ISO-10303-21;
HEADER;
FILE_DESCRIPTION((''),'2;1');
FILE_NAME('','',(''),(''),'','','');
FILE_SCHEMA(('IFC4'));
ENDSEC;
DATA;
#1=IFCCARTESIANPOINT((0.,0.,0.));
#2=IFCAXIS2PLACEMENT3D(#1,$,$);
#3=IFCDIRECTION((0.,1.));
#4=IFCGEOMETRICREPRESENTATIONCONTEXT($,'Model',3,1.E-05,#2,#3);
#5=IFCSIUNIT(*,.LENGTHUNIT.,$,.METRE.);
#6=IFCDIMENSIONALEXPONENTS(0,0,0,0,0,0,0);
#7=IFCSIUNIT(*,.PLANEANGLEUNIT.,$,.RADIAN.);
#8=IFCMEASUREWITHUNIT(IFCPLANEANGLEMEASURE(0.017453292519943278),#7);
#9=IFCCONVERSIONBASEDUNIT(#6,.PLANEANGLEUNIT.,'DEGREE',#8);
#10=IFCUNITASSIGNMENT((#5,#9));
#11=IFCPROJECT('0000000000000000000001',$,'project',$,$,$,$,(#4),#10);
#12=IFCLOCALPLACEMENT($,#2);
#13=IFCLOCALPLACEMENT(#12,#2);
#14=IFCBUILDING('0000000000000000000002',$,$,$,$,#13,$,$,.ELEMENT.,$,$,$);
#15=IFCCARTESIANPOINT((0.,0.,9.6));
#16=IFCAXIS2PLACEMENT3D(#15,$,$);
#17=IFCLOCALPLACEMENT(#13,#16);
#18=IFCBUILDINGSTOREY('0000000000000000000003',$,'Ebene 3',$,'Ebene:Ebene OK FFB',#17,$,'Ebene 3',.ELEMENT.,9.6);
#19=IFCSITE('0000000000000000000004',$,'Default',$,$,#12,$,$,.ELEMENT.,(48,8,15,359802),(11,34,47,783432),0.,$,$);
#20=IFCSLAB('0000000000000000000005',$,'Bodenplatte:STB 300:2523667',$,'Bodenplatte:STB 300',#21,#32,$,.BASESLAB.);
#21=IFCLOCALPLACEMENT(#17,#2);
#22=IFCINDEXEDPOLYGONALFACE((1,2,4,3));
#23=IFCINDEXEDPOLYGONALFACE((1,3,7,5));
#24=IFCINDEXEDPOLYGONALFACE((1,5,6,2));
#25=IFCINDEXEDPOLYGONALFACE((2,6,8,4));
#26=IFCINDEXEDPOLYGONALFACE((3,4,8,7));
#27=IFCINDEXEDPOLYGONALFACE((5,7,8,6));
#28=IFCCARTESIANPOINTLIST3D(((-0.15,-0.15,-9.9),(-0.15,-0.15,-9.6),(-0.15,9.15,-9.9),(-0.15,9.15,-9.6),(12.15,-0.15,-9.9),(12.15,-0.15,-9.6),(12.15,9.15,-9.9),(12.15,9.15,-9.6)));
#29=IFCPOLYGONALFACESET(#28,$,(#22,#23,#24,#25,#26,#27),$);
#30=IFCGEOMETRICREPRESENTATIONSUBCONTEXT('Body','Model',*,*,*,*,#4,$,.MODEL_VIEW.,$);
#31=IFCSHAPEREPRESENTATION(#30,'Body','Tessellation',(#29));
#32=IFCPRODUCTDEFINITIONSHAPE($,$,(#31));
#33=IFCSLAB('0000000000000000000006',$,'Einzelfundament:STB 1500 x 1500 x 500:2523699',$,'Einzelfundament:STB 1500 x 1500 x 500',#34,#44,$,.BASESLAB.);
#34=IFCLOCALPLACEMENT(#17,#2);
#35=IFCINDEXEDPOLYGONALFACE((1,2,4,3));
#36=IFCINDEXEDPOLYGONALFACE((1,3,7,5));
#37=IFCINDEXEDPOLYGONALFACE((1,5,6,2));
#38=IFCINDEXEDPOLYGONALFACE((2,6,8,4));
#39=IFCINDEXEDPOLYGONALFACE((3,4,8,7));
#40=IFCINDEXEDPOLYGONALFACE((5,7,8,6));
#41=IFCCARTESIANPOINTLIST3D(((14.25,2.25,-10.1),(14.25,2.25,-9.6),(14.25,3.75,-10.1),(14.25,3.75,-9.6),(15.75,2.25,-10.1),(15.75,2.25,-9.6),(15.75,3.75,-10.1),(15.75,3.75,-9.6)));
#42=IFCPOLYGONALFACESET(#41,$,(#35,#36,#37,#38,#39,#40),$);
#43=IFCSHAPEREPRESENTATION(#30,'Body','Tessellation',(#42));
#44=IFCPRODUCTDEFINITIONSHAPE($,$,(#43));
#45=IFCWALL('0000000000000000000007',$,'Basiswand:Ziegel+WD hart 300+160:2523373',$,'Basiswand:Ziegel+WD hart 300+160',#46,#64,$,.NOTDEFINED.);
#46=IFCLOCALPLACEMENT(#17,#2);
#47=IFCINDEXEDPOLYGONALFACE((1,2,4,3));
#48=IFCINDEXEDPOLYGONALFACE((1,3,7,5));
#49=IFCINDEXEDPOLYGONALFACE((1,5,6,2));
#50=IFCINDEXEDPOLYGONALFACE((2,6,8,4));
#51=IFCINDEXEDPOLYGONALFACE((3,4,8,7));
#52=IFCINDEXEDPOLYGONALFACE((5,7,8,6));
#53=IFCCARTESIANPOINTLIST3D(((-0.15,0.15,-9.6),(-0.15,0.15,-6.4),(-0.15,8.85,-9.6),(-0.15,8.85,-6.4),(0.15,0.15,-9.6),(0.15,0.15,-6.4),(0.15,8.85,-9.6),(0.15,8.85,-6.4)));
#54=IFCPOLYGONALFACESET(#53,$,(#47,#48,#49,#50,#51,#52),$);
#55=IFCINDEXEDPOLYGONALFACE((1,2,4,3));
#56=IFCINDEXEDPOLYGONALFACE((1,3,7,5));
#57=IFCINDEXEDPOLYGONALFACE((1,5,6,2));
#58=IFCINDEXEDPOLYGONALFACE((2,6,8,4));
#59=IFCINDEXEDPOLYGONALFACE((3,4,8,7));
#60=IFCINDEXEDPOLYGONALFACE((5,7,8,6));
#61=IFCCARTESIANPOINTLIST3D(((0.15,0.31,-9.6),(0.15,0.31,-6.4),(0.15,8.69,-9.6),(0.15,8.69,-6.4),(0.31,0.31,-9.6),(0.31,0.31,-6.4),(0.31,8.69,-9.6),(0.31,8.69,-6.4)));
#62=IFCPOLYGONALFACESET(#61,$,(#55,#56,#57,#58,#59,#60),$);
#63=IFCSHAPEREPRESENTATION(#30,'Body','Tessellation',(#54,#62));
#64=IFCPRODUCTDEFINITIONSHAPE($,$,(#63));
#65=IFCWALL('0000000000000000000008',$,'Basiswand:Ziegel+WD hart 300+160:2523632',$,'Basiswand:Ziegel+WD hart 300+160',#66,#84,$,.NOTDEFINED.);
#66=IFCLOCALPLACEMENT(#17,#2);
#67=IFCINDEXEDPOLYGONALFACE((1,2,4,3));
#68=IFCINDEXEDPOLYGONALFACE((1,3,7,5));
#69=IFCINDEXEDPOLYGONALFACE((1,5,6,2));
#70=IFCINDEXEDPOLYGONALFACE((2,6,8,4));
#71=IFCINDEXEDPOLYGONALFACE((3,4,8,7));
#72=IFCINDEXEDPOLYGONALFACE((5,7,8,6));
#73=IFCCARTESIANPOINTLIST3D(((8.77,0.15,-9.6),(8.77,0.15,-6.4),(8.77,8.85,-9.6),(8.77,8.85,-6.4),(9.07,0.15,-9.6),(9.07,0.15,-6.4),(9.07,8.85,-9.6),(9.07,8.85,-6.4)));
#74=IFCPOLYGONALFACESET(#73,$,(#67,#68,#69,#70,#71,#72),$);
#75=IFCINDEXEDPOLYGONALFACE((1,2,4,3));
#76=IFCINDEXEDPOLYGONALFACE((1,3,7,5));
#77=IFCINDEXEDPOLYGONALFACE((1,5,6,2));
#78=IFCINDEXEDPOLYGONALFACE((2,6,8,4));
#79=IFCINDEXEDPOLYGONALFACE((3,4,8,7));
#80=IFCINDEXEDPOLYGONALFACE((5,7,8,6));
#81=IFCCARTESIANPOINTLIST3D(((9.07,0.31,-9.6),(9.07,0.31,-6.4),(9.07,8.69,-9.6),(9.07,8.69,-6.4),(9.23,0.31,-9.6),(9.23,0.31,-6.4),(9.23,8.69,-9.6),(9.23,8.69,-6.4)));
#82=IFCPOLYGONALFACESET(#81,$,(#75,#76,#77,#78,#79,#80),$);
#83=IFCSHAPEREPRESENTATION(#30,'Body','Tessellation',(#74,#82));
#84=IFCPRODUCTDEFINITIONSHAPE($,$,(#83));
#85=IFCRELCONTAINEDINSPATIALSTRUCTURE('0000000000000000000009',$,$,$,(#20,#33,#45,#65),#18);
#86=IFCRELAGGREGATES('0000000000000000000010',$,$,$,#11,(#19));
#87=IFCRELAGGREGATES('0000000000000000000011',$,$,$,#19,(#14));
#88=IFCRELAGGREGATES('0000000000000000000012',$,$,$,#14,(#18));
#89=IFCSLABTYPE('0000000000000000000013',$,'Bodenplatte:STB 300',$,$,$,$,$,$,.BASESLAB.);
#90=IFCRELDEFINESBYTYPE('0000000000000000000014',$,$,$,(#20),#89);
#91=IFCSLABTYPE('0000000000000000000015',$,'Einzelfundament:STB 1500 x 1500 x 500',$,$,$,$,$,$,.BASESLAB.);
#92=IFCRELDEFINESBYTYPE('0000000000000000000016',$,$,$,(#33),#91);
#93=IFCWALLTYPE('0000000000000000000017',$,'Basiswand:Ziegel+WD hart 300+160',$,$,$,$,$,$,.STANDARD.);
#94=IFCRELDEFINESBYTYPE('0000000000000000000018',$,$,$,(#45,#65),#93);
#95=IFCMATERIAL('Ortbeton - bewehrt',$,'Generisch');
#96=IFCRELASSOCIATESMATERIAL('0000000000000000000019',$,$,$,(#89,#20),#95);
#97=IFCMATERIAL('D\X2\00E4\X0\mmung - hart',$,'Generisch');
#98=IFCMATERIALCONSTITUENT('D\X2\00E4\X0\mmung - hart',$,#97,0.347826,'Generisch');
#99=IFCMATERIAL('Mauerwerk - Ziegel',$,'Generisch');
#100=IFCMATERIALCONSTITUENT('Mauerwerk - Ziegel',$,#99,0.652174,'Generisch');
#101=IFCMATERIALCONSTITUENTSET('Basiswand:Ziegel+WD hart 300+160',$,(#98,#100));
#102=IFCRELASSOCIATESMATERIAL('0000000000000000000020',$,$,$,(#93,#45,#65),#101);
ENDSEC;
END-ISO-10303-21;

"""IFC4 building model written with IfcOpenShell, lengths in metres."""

from ifc_helpers import new_model, entity, si_unit, converted_unit, direction, frame, origin, place, context, subcontext, project, spatial, indexed_curve, outline, extrude, material, constituent, constituent_set, type_object, element, save


model = new_model("IFC4")

# Units and contexts
model_context = context("Model", 3, precision=1e-05, world=origin(), true_north=direction((0.0, 1.0)))
body_context = subcontext(model_context, "Body", "Model", "MODEL_VIEW")
ifc_project = project(units=[si_unit("LENGTHUNIT", "METRE"), converted_unit("PLANEANGLEUNIT", "DEGREE", entity("IfcPlaneAngleMeasure", 0.017453292519943278), si_unit("PLANEANGLEUNIT", "RADIAN"), dimensions=[0, 0, 0, 0, 0, 0, 0])], contexts=[model_context])

# Site, building, storey
site_placement = place(None, origin())
site = spatial("IfcSite", under=ifc_project, at=site_placement, Name="Default", CompositionType="ELEMENT", RefLatitude=(48, 8, 15, 359802), RefLongitude=(11, 34, 47, 783432), RefElevation=0.0)
building_placement = place(site_placement, origin())
building = spatial("IfcBuilding", under=site, at=building_placement, CompositionType="ELEMENT")
storey_placement = place(building_placement, frame((0.0, 0.0, 9.6)))
storey = spatial("IfcBuildingStorey", under=building, at=storey_placement, Name="Ebene 3", ObjectType="Ebene:Ebene OK FFB", LongName="Ebene 3", CompositionType="ELEMENT", Elevation=9.6)

# Slabs
ifc_material_1 = material(Name="Ortbeton - bewehrt", Category="Generisch")
slab_type_1 = type_object("IfcSlabType", Name="Bodenplatte:STB 300", PredefinedType="BASESLAB", material=ifc_material_1)
slab_1_placement = place(storey_placement, origin())
element("IfcSlab", 1, at=slab_1_placement, inside=storey, type_object=slab_type_1, material=ifc_material_1, Name="Bodenplatte:STB 300:2523667", ObjectType="Bodenplatte:STB 300", PredefinedType="BASESLAB", context=body_context, shape_type="SweptSolid", body=[
    extrude(outline(indexed_curve([(-4.65, -6.15), (4.65, -6.15), (4.65, 6.15), (-4.65, 6.15), (-4.65, -6.15)], self_intersect=False)), frame((6.0, 4.5, -9.6), z_axis=(0.0, 0.0, -1.0), x_axis=(0.0, 1.0, 0.0)), (0.0, 0.0, 1.0), 0.3),
])
slab_type_2 = type_object("IfcSlabType", Name="Einzelfundament:STB 1500 x 1500 x 500", PredefinedType="BASESLAB")
slab_2_placement = place(storey_placement, origin())
element("IfcSlab", 2, at=slab_2_placement, inside=storey, type_object=slab_type_2, Name="Einzelfundament:STB 1500 x 1500 x 500:2523699", ObjectType="Einzelfundament:STB 1500 x 1500 x 500", PredefinedType="BASESLAB", context=body_context, shape_type="SweptSolid", body=[
    extrude(outline(indexed_curve([(-0.75, -0.75), (0.75, -0.75), (0.75, 0.75), (-0.75, 0.75), (-0.75, -0.75)], self_intersect=False)), frame((15.0, 3.0, -10.1), z_axis=(0.0, 0.0, 1.0), x_axis=(-1.0, 0.0, 0.0)), (0.0, 0.0, 1.0), 0.5),
])

# Shared definitions
ifc_material_2 = material(Name="Dämmung - hart", Category="Generisch")
ifc_constituent_1 = constituent(ifc_material_2, Name="Dämmung - hart", Category="Generisch", fraction=0.347826)
ifc_material_3 = material(Name="Mauerwerk - Ziegel", Category="Generisch")
ifc_constituent_2 = constituent(ifc_material_3, Name="Mauerwerk - Ziegel", Category="Generisch", fraction=0.652174)
ifc_constituent_set = constituent_set(constituents=[ifc_constituent_1, ifc_constituent_2], Name="Basiswand:Ziegel+WD hart 300+160")
wall_type = type_object("IfcWallType", Name="Basiswand:Ziegel+WD hart 300+160", PredefinedType="STANDARD", material=ifc_constituent_set)

# Walls
wall_1_placement = place(storey_placement, frame((0.08, 8.69, -9.6), z_axis=(0.0, 0.0, 1.0), x_axis=(0.0, -1.0, 0.0)))
element("IfcWall", 3, at=wall_1_placement, inside=storey, type_object=wall_type, material=ifc_constituent_set, Name="Basiswand:Ziegel+WD hart 300+160:2523373", ObjectType="Basiswand:Ziegel+WD hart 300+160", PredefinedType="NOTDEFINED", context=body_context, shape_type="SweptSolid", body=[
    extrude(outline(indexed_curve([(-0.15, -4.35), (0.15, -4.35), (0.15, 4.35), (-0.15, 4.35), (-0.15, -4.35)], self_intersect=False)), frame((4.19, -0.08, 0.0), z_axis=(0.0, 0.0, 1.0), x_axis=(0.0, 1.0, 0.0)), (0.0, 0.0, 1.0), 3.2),
    extrude(outline(indexed_curve([(-0.08, -4.19), (0.08, -4.19), (0.08, 4.19), (-0.08, 4.19), (-0.08, -4.19)], self_intersect=False)), frame((4.19, 0.15, 0.0), z_axis=(0.0, 0.0, 1.0), x_axis=(0.0, -1.0, 0.0)), (0.0, 0.0, 1.0), 3.2),
])
wall_2_placement = place(storey_placement, frame((9.0, 8.69, -9.6), z_axis=(0.0, 0.0, 1.0), x_axis=(0.0, -1.0, 0.0)))
element("IfcWall", 4, at=wall_2_placement, inside=storey, type_object=wall_type, material=ifc_constituent_set, Name="Basiswand:Ziegel+WD hart 300+160:2523632", ObjectType="Basiswand:Ziegel+WD hart 300+160", PredefinedType="NOTDEFINED", context=body_context, shape_type="SweptSolid", body=[
    extrude(outline(indexed_curve([(-0.15, -4.35), (0.15, -4.35), (0.15, 4.35), (-0.15, 4.35), (-0.15, -4.35)], self_intersect=False)), frame((4.19, -0.08, 0.0), z_axis=(0.0, 0.0, 1.0), x_axis=(0.0, 1.0, 0.0)), (0.0, 0.0, 1.0), 3.2),
    extrude(outline(indexed_curve([(-0.08, -4.19), (0.08, -4.19), (0.08, 4.19), (-0.08, 4.19), (-0.08, -4.19)], self_intersect=False)), frame((4.19, 0.15, 0.0), z_axis=(0.0, 0.0, 1.0), x_axis=(0.0, -1.0, 0.0)), (0.0, 0.0, 1.0), 3.2),
])

save(model, "model.ifc")
